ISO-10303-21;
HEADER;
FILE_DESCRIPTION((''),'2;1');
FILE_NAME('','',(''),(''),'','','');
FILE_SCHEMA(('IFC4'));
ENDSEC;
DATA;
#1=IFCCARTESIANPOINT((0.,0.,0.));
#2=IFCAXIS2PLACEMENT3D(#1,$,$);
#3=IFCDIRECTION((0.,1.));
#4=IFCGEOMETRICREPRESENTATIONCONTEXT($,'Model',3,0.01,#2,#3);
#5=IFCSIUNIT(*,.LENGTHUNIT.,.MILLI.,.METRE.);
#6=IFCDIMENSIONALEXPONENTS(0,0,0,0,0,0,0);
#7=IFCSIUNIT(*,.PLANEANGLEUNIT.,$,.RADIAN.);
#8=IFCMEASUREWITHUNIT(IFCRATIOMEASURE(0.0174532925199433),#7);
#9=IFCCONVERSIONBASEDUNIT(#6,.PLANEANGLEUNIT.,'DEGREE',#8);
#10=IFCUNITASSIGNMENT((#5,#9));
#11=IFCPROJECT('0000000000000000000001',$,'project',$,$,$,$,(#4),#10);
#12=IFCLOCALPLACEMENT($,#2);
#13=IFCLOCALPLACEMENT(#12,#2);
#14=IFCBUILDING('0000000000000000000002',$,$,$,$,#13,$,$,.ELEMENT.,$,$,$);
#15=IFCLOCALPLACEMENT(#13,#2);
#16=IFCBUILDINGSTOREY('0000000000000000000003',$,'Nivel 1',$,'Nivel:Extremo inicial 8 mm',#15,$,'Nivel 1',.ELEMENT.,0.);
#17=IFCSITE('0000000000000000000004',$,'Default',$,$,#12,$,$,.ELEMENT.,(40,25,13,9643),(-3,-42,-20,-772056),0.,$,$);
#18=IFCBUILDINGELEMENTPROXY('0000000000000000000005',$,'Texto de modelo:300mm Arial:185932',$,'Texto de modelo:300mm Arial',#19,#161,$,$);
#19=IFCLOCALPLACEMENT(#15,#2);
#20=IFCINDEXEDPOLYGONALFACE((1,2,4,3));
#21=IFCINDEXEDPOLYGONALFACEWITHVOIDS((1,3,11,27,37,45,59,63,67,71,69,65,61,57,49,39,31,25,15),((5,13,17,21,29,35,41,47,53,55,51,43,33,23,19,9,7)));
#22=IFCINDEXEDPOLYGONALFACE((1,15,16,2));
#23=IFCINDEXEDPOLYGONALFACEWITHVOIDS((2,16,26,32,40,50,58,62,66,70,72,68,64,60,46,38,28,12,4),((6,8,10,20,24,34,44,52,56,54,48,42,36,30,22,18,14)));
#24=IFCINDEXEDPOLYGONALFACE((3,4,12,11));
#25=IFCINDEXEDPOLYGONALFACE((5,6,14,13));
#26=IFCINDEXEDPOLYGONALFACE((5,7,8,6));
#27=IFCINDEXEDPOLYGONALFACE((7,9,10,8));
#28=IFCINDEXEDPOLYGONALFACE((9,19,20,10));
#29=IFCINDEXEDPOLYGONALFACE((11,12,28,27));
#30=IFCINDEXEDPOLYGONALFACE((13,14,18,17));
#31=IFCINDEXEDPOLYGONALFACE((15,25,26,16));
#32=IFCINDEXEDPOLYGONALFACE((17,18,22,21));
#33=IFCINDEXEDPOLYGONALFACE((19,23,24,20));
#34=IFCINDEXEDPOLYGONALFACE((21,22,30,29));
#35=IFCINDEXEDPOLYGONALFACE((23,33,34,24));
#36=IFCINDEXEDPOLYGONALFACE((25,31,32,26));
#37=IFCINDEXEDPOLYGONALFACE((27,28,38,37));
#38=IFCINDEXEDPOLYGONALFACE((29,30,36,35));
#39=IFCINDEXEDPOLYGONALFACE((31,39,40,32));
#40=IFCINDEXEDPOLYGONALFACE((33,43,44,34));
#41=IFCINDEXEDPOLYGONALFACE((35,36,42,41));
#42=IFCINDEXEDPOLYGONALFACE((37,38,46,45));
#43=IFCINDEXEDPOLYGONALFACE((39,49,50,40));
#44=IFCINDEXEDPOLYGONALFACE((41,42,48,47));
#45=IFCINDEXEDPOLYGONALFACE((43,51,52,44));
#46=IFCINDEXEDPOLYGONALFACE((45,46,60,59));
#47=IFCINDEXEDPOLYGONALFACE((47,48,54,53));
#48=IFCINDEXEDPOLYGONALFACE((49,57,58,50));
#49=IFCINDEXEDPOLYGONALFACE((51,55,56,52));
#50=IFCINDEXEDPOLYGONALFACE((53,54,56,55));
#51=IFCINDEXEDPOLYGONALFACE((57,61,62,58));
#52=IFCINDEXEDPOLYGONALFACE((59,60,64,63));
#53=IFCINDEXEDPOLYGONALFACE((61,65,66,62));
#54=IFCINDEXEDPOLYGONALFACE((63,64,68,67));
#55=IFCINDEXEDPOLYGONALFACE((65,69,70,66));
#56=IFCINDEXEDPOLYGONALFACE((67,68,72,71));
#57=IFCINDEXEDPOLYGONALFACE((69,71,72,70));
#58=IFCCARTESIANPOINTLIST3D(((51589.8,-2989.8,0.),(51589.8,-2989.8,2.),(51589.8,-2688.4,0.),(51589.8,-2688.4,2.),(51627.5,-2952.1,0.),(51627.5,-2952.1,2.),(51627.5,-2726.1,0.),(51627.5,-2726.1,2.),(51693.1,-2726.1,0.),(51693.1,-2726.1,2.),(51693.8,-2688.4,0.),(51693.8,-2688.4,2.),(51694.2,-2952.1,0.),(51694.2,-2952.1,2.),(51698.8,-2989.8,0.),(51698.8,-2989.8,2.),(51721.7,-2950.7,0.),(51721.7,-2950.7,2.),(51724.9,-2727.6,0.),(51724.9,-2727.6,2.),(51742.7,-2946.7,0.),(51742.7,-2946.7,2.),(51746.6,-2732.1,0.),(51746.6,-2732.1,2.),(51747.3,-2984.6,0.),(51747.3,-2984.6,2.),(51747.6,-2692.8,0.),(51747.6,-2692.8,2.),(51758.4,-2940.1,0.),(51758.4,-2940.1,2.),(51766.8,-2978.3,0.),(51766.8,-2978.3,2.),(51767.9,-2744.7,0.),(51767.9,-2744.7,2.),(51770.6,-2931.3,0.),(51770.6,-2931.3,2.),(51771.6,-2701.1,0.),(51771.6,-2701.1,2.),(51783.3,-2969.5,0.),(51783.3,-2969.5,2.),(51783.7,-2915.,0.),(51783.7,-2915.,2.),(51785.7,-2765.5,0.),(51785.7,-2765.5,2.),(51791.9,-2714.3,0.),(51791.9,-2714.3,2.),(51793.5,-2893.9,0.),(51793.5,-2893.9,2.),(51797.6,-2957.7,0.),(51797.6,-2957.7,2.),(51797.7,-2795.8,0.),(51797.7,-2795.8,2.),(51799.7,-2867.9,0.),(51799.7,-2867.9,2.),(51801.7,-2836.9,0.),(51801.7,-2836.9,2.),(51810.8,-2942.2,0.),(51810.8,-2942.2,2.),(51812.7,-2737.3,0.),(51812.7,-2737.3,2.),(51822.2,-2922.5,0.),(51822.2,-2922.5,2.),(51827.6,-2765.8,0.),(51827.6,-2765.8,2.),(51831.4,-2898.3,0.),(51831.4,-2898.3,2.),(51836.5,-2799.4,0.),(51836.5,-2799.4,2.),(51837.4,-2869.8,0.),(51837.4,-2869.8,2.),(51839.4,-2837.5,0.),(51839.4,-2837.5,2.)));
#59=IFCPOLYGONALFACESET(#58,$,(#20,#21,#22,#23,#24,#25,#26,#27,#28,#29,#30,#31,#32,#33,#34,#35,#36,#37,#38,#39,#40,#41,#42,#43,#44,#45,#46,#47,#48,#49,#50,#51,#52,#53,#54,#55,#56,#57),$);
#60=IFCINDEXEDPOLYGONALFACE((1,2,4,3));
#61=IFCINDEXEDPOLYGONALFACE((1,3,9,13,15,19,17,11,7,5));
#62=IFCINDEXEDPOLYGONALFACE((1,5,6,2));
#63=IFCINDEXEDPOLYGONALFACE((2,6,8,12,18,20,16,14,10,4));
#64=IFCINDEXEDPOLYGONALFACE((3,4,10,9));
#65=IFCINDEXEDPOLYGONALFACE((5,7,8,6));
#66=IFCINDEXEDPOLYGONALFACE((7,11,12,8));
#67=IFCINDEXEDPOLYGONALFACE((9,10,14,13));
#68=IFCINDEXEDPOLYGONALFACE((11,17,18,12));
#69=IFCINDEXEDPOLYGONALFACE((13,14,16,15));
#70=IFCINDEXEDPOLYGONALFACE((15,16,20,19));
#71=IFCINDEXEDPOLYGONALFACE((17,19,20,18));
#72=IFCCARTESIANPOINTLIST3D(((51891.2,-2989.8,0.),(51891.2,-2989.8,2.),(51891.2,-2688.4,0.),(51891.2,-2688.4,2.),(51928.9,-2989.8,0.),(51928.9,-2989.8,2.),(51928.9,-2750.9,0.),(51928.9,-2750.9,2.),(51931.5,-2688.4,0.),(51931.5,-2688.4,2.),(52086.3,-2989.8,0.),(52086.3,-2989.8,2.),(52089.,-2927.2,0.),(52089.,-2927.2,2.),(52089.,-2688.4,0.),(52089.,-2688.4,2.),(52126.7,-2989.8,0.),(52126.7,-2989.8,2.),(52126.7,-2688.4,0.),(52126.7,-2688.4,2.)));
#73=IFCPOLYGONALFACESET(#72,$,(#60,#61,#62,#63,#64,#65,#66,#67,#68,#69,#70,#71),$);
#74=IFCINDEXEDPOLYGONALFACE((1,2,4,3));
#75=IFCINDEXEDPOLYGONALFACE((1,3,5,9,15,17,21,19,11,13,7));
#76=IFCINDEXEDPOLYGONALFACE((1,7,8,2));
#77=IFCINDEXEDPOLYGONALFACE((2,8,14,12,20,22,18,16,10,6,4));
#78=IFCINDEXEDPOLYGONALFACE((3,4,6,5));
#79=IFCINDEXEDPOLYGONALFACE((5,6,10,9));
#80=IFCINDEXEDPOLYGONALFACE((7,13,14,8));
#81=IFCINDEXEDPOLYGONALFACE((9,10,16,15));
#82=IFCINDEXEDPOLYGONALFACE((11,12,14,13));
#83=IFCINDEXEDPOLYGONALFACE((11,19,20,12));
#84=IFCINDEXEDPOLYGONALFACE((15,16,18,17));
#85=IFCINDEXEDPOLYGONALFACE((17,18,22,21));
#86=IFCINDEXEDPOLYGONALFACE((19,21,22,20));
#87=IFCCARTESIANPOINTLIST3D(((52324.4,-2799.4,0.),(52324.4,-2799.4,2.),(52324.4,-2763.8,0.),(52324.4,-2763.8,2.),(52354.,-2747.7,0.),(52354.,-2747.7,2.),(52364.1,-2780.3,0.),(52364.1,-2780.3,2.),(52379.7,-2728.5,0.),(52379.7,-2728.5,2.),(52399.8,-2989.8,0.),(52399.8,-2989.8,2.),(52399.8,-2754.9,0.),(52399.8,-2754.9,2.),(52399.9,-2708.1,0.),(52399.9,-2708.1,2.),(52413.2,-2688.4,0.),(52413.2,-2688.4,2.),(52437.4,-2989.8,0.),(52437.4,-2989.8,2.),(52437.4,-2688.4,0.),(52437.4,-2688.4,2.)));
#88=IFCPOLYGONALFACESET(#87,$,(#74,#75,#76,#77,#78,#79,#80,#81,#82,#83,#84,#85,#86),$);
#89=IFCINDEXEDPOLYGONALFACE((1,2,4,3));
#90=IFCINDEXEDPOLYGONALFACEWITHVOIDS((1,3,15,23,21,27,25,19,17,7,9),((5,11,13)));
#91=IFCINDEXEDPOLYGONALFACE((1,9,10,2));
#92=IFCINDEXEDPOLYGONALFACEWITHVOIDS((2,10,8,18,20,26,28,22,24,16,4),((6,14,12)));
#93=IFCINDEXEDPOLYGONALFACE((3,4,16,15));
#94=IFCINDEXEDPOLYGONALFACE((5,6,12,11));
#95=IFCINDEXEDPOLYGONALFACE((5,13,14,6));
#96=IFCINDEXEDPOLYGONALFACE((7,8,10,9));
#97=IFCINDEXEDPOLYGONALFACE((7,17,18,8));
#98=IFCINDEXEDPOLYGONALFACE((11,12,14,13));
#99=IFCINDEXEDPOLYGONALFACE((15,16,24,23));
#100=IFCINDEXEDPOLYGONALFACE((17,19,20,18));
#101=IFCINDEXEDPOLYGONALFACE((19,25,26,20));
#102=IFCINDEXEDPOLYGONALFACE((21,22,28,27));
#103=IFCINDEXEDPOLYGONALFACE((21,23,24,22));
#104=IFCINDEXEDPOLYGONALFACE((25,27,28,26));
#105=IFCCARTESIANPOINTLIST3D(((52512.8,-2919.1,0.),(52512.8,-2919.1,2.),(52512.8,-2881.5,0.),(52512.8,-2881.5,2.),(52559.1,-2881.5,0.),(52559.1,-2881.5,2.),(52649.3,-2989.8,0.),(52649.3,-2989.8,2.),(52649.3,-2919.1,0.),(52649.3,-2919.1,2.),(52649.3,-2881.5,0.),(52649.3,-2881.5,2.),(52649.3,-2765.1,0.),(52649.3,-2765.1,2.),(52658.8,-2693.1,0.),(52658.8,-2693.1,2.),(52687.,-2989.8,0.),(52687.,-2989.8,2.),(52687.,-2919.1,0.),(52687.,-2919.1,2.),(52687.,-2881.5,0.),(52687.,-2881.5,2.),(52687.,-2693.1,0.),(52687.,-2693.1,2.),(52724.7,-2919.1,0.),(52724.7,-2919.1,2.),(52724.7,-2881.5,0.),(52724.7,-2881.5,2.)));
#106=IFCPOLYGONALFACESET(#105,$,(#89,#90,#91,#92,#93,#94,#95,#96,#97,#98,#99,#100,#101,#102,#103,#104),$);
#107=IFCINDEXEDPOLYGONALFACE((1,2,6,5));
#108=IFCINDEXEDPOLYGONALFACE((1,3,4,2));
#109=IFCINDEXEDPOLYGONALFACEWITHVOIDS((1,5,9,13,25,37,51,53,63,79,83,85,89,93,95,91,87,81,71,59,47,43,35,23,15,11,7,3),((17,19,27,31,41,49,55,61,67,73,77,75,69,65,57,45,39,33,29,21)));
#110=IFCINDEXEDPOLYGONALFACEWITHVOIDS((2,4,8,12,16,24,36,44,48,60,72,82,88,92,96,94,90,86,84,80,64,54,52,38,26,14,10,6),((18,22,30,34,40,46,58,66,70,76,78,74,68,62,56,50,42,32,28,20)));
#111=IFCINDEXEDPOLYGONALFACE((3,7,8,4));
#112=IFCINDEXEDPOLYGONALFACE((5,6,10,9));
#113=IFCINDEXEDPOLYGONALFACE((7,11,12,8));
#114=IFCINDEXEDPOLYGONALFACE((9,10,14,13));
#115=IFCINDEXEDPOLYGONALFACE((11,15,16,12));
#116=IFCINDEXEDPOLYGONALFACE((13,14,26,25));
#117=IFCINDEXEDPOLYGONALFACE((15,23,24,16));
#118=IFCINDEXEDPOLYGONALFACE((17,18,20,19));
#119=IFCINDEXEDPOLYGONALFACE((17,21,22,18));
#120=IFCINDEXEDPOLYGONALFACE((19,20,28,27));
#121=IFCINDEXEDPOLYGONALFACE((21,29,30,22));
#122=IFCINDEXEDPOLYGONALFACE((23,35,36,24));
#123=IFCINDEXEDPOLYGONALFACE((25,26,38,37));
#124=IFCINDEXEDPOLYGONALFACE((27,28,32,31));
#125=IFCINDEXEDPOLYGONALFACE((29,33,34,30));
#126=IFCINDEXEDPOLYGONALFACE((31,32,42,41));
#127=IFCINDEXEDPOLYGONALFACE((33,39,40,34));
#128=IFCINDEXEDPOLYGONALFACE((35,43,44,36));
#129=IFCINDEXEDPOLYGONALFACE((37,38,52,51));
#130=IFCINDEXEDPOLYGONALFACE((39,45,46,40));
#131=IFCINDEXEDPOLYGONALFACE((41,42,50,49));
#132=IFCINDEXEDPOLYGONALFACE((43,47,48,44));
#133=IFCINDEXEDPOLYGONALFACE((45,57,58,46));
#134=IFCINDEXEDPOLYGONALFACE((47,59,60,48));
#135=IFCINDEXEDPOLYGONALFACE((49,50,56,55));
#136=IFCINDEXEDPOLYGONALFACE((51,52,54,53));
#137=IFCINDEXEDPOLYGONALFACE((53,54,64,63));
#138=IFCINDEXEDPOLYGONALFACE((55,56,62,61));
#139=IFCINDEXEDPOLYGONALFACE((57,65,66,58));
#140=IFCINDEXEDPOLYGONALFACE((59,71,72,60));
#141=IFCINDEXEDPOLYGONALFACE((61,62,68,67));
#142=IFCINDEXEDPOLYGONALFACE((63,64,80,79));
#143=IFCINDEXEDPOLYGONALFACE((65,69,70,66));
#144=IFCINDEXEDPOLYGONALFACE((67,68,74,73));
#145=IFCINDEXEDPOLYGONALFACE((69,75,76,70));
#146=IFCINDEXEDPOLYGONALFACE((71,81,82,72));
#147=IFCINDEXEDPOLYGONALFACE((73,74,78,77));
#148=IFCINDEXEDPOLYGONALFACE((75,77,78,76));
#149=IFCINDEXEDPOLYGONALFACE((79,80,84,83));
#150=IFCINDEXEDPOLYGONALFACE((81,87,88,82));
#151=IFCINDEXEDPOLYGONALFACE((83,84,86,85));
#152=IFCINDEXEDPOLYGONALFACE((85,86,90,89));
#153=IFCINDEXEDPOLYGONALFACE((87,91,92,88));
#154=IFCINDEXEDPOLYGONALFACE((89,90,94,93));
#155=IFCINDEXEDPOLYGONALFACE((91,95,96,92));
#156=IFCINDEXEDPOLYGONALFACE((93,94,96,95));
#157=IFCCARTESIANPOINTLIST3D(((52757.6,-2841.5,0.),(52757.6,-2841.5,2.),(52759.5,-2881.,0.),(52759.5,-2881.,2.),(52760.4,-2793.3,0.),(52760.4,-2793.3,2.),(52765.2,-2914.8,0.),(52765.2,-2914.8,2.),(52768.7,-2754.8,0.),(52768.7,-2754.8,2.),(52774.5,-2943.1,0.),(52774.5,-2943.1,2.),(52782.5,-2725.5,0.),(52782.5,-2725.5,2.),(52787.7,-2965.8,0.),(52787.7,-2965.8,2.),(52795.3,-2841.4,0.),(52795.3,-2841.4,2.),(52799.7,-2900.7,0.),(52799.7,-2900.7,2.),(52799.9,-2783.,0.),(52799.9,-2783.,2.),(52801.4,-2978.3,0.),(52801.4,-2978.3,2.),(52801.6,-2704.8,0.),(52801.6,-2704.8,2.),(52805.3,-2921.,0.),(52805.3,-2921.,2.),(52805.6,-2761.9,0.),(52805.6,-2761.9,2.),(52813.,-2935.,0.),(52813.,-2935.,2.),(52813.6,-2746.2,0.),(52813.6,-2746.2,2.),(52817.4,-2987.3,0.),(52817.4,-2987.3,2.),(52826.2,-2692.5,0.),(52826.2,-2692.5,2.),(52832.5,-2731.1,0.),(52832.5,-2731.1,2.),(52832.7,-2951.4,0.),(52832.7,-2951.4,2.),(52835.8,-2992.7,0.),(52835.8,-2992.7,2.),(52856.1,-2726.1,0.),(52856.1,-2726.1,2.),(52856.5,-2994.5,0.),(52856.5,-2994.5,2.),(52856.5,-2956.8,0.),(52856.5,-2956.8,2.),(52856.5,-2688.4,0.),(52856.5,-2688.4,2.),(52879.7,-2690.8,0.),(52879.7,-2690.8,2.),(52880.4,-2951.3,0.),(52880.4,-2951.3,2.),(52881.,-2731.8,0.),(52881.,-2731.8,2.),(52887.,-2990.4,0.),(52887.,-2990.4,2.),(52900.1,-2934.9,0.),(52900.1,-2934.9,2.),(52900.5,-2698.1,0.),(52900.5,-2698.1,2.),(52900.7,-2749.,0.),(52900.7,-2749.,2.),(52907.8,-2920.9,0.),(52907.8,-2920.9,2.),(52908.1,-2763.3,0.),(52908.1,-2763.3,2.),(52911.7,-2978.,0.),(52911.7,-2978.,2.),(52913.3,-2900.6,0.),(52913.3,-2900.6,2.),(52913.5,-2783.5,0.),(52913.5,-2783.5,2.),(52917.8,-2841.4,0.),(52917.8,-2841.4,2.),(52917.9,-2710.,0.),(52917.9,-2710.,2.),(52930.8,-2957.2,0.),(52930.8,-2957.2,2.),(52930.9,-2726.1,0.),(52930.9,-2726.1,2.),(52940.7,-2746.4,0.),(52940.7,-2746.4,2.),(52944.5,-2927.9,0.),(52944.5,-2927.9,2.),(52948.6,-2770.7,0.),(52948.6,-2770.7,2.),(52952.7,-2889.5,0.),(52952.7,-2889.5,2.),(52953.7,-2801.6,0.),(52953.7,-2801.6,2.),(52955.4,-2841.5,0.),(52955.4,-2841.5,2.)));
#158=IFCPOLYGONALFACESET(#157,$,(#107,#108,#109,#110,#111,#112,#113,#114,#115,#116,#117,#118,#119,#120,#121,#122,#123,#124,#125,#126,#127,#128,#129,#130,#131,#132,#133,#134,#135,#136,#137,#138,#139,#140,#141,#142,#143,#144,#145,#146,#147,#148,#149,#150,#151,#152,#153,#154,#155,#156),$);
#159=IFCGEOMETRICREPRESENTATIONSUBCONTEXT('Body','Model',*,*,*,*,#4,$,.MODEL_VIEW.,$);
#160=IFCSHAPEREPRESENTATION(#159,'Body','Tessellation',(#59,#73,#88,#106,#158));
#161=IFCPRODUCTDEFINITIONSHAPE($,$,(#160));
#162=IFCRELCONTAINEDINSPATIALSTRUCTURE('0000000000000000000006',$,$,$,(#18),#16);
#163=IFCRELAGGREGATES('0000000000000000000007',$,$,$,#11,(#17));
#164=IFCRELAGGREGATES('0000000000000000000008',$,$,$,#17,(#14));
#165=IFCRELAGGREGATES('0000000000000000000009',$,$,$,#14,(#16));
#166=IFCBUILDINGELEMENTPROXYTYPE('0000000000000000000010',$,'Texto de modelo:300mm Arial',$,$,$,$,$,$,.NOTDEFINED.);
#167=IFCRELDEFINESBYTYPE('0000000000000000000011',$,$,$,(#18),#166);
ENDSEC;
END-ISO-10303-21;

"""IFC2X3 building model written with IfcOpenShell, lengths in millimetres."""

from ifc_helpers import new_model, entity, si_unit, converted_unit, direction, frame, origin, place, context, subcontext, project, spatial, polyline, outline, extrude, type_object, element, save


model = new_model("IFC2X3")

# Units and contexts
model_context = context("Model", 3, precision=0.01, world=origin(), true_north=direction((0.0, 1.0)))
body_context = subcontext(model_context, "Body", "Model", "MODEL_VIEW")
ifc_project = project(units=[si_unit("LENGTHUNIT", "METRE", prefix="MILLI"), converted_unit("PLANEANGLEUNIT", "DEGREE", entity("IfcRatioMeasure", 0.0174532925199433), si_unit("PLANEANGLEUNIT", "RADIAN"), dimensions=[0, 0, 0, 0, 0, 0, 0])], contexts=[model_context])

# Site, building, storey
site_placement = place(None, origin())
site = spatial("IfcSite", under=ifc_project, at=site_placement, Name="Default", CompositionType="ELEMENT", RefLatitude=(40, 25, 13, 9643), RefLongitude=(-3, -42, -20, -772056), RefElevation=0.0)
building_placement = place(site_placement, origin())
building = spatial("IfcBuilding", under=site, at=building_placement, CompositionType="ELEMENT")
storey_placement = place(building_placement, origin())
storey = spatial("IfcBuildingStorey", under=building, at=storey_placement, Name="Nivel 1", ObjectType="Nivel:Extremo inicial 8 mm", LongName="Nivel 1", CompositionType="ELEMENT", Elevation=0.0)

# Building element proxy
building_element_proxy_type_1 = type_object("IfcBuildingElementProxyType", Name="Texto de modelo:300mm Arial", PredefinedType="NOTDEFINED")
proxy_1_placement = place(storey_placement, frame((51589.8, -2994.5, 0.0)))
element("IfcBuildingElementProxy", 1, at=proxy_1_placement, inside=storey, type_object=building_element_proxy_type_1, Name="Texto de modelo:300mm Arial:185932", ObjectType="Texto de modelo:300mm Arial", context=body_context, shape_type="SweptSolid", body=[
    extrude(outline(polyline([(-178.4, -141.0), (-69.4, -141.0), (-21.0, -135.8), (-1.4, -129.5), (15.0, -120.7), (29.4, -108.9), (42.6, -93.4), (54.0, -73.7), (63.2, -49.5), (69.2, -21.0), (71.2, 11.3), (68.2, 49.4), (59.3, 83.0), (44.5, 111.5), (23.7, 134.5), (3.4, 147.7), (-20.6, 156.1), (-74.4, 160.4), (-178.4, 160.4), (-178.4, -141.0)]), holes=[polyline([(-140.7, -103.3), (-140.7, 122.7), (-75.1, 122.7), (-43.3, 121.2), (-21.7, 116.7), (-0.4, 104.1), (17.4, 83.3), (29.5, 53.0), (33.5, 11.9), (31.5, -19.1), (25.3, -45.1), (15.5, -66.2), (2.4, -82.5), (-9.8, -91.3), (-25.6, -97.9), (-46.5, -101.9), (-74.1, -103.3), (-140.7, -103.3)])]), frame((178.4, 145.7, 0.0)), (0.0, 0.0, 1.0), 2.0),
    extrude(outline(polyline([(-117.7, -150.7), (-80.1, -150.7), (-80.1, 88.1), (77.4, -150.7), (117.7, -150.7), (117.7, 150.7), (80.1, 150.7), (80.1, -88.1), (-77.4, 150.7), (-117.7, 150.7), (-117.7, -150.7)])), frame((419.1, 155.4, 0.0)), (0.0, 0.0, 1.0), 2.0),
    extrude(outline(polyline([(-204.4, -52.5), (97.0, -52.5), (97.0, -28.2), (77.2, -14.9), (56.9, 5.3), (37.7, 30.9), (21.6, 60.5), (-14.0, 60.5), (5.0, 20.8), (30.4, -14.9), (-204.4, -14.9), (-204.4, -52.5)])), frame((795.1, 209.1, 0.0), z_axis=(0.0, 0.0, 1.0), x_axis=(0.0, 1.0, 0.0)), (0.0, 0.0, 1.0), 2.0),
    extrude(outline(polyline([(-3.4, -109.2), (34.2, -109.2), (34.2, -38.5), (71.9, -38.5), (71.9, -0.9), (34.2, -0.9), (34.2, 187.5), (6.0, 187.5), (-140.0, -0.9), (-140.0, -38.5), (-3.4, -38.5), (-3.4, -109.2)]), holes=[polyline([(-3.4, -0.9), (-93.6, -0.9), (-3.4, 115.5), (-3.4, -0.9)])]), frame((1062.9, 113.9, 0.0)), (0.0, 0.0, 1.0), 2.0),
    extrude(outline(polyline([(-5.6, -99.5), (33.9, -99.5), (68.0, -95.5), (96.7, -87.5), (120.0, -75.5), (133.2, -62.4), (142.9, -46.8), (149.1, -28.7), (151.9, -8.0), (149.2, 22.6), (138.0, 47.8), (118.2, 67.9), (89.5, 82.9), (51.6, 93.0), (3.8, 98.0), (-36.2, 98.2), (-67.3, 94.5), (-91.9, 87.9), (-112.6, 79.0), (-129.4, 66.8), (-142.0, 50.0), (-150.3, 29.6), (-153.8, 6.5), (-151.2, -23.9), (-140.1, -49.1), (-120.3, -69.2), (-91.7, -84.4), (-53.6, -94.5), (-5.6, -99.5)]), holes=[polyline([(-3.9, -61.9), (-62.1, -54.6), (-82.9, -47.9), (-98.1, -39.2), (-112.3, -19.5), (-116.2, 4.3), (-109.3, 28.9), (-91.2, 47.7), (-76.5, 54.5), (-56.1, 58.9), (1.9, 60.4), (60.8, 53.2), (80.8, 46.7), (94.5, 38.3), (109.9, 17.8), (114.3, -6.3), (107.7, -29.8), (90.4, -48.7), (76.0, -55.8), (55.5, -60.3), (-3.9, -61.9)])]), frame((1267.5, 152.1, 0.0), z_axis=(0.0, 0.0, 1.0), x_axis=(0.047515, -0.998871, 0.0)), (0.0, 0.0, 1.0), 2.0),
])

save(model, "model.ifc")
